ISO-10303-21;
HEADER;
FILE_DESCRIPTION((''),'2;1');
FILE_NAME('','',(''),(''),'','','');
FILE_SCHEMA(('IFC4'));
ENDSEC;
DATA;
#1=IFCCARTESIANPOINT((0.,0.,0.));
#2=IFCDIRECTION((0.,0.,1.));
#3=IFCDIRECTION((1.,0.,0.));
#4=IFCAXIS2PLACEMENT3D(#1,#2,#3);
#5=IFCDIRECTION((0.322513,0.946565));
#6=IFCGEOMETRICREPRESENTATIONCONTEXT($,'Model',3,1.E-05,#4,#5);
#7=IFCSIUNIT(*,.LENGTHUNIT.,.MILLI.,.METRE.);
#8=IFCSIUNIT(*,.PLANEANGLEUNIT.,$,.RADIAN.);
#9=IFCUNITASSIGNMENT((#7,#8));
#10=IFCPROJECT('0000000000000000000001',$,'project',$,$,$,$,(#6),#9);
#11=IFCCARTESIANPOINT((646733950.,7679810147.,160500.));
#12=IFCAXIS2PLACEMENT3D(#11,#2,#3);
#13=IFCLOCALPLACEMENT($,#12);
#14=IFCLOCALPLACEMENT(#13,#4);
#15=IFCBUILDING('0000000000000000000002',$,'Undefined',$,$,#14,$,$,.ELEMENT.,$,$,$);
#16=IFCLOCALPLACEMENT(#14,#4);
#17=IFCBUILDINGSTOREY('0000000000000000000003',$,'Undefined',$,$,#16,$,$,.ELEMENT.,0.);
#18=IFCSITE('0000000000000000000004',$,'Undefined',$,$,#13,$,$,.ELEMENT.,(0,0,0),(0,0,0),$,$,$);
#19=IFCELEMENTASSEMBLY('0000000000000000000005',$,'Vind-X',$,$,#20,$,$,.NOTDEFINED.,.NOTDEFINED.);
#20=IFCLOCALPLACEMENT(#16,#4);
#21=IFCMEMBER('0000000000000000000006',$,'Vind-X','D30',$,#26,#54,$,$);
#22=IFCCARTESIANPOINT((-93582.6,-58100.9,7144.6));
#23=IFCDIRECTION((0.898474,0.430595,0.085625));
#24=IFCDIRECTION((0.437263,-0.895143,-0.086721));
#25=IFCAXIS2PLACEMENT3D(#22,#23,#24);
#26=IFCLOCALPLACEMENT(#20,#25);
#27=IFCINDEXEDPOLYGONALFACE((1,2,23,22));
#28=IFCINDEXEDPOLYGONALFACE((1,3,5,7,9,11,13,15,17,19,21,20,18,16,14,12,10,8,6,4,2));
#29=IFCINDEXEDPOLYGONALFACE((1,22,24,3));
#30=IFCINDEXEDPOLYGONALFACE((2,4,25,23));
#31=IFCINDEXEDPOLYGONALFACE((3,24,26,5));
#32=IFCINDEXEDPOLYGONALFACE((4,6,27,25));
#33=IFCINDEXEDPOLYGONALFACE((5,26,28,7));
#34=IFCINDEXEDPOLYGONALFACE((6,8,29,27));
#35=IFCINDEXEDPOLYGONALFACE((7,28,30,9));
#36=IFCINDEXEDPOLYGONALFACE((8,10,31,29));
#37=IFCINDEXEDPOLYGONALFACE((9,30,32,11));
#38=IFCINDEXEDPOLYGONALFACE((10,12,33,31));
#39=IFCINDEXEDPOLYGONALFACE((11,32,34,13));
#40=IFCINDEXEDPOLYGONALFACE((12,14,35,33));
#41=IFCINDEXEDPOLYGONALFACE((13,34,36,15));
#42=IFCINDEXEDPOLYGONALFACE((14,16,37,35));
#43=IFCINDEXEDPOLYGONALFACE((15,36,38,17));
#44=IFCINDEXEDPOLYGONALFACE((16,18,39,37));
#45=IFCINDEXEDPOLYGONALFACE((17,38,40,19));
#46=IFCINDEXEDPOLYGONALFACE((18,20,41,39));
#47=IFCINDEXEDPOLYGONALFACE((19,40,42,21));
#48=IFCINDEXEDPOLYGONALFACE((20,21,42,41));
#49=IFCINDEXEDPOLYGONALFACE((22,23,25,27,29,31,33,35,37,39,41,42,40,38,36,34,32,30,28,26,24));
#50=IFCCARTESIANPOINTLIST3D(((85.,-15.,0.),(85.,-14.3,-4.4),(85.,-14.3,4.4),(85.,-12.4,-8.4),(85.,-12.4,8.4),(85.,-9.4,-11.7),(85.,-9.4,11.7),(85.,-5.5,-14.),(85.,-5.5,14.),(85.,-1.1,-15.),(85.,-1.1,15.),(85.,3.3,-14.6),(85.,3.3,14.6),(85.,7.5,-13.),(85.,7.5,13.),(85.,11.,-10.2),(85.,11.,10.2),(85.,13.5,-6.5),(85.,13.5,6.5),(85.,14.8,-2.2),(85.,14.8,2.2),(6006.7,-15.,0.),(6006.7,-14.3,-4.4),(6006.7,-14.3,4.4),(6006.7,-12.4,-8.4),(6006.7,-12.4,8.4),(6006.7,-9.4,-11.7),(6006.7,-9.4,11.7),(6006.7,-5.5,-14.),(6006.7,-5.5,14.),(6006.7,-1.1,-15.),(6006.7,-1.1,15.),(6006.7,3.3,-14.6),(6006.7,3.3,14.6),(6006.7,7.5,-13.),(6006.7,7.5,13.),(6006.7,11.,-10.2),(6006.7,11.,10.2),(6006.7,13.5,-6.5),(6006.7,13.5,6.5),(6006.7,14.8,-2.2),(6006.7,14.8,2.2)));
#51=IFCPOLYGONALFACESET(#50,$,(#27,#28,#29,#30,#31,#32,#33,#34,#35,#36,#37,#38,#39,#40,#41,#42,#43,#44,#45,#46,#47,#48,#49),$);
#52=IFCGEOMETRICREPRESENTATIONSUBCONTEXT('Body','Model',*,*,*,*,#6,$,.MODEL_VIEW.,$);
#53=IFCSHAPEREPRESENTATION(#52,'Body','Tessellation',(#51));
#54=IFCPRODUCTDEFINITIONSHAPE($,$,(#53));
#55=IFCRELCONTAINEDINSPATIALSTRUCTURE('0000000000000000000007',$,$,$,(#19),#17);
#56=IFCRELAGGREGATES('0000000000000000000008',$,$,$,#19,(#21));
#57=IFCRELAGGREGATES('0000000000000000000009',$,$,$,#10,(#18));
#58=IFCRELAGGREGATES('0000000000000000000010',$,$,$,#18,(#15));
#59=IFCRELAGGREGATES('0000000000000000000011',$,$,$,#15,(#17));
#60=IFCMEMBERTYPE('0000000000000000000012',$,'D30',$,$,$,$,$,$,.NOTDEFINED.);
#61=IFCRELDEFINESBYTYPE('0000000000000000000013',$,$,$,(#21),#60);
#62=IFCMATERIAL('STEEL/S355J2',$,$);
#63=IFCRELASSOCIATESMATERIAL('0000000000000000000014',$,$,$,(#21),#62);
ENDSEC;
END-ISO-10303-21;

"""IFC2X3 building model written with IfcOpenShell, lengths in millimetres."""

from ifc_helpers import new_model, si_unit, direction, frame, origin_with_axes, origin_2d_with_axis, place, context, subcontext, project, spatial, circle, extrude, clip, halfspace, material, type_object, element, aggregate, save


model = new_model("IFC2X3")

# Units and contexts
model_context = context("Model", 3, precision=1e-05, world=origin_with_axes(), true_north=direction((0.322513, 0.946565)))
body_context = subcontext(model_context, "Body", "Model", "MODEL_VIEW")
ifc_project = project(units=[si_unit("LENGTHUNIT", "METRE", prefix="MILLI"), si_unit("PLANEANGLEUNIT", "RADIAN")], contexts=[model_context])

# Site, building, storey
site_placement = place(None, frame((646733950.0, 7679810147.0, 160500.0), z_axis=(0.0, 0.0, 1.0), x_axis=(1.0, 0.0, 0.0)))
site = spatial("IfcSite", under=ifc_project, at=site_placement, Name="Undefined", CompositionType="ELEMENT", RefLatitude=(0, 0, 0), RefLongitude=(0, 0, 0))
building_placement = place(site_placement, origin_with_axes())
building = spatial("IfcBuilding", under=site, at=building_placement, Name="Undefined", CompositionType="ELEMENT")
storey_placement = place(building_placement, origin_with_axes())
storey = spatial("IfcBuildingStorey", under=building, at=storey_placement, Name="Undefined", CompositionType="ELEMENT", Elevation=0.0)

# Shared definitions
ifc_material_1 = material(Name="STEEL/S355J2")

# Element assembly, member
assembly_1_placement = place(storey_placement, origin_with_axes())
assembly_1 = element("IfcElementAssembly", 1, at=assembly_1_placement, inside=storey, Name="Vind-X", AssemblyPlace="NOTDEFINED", PredefinedType="NOTDEFINED")
member_type = type_object("IfcMemberType", Name="D30", PredefinedType="NOTDEFINED")
member_placement = place(assembly_1_placement, frame((-93582.6, -58100.9, 7144.6), z_axis=(0.898474, 0.430595, 0.085625), x_axis=(0.437263, -0.895143, -0.086721)))
member = element("IfcMember", 2, at=member_placement, type_object=member_type, material=ifc_material_1, Name="Vind-X", Description="D30", context=body_context, shape_type="Clipping", body=[
    clip(clip(extrude(circle(Radius=15.0, at=origin_2d_with_axis()), frame((6671.7, 0.0, 0.0), z_axis=(-1.0, 0.0, 0.0), x_axis=(0.0, -1.0, 0.0)), (0.0, 0.0, 1.0), 6671.7), halfspace(frame((6006.7, -6.0, 10.2), z_axis=(1.0, 0.0, 0.0), x_axis=(0.0, 1.0, 0.0)), False)), halfspace(frame((85.0, -6.0, 16.0), z_axis=(1.0, 0.0, 0.0), x_axis=(0.0, 1.0, 0.0)), True)),
])

aggregate(assembly_1, [member])

save(model, "model.ifc")
